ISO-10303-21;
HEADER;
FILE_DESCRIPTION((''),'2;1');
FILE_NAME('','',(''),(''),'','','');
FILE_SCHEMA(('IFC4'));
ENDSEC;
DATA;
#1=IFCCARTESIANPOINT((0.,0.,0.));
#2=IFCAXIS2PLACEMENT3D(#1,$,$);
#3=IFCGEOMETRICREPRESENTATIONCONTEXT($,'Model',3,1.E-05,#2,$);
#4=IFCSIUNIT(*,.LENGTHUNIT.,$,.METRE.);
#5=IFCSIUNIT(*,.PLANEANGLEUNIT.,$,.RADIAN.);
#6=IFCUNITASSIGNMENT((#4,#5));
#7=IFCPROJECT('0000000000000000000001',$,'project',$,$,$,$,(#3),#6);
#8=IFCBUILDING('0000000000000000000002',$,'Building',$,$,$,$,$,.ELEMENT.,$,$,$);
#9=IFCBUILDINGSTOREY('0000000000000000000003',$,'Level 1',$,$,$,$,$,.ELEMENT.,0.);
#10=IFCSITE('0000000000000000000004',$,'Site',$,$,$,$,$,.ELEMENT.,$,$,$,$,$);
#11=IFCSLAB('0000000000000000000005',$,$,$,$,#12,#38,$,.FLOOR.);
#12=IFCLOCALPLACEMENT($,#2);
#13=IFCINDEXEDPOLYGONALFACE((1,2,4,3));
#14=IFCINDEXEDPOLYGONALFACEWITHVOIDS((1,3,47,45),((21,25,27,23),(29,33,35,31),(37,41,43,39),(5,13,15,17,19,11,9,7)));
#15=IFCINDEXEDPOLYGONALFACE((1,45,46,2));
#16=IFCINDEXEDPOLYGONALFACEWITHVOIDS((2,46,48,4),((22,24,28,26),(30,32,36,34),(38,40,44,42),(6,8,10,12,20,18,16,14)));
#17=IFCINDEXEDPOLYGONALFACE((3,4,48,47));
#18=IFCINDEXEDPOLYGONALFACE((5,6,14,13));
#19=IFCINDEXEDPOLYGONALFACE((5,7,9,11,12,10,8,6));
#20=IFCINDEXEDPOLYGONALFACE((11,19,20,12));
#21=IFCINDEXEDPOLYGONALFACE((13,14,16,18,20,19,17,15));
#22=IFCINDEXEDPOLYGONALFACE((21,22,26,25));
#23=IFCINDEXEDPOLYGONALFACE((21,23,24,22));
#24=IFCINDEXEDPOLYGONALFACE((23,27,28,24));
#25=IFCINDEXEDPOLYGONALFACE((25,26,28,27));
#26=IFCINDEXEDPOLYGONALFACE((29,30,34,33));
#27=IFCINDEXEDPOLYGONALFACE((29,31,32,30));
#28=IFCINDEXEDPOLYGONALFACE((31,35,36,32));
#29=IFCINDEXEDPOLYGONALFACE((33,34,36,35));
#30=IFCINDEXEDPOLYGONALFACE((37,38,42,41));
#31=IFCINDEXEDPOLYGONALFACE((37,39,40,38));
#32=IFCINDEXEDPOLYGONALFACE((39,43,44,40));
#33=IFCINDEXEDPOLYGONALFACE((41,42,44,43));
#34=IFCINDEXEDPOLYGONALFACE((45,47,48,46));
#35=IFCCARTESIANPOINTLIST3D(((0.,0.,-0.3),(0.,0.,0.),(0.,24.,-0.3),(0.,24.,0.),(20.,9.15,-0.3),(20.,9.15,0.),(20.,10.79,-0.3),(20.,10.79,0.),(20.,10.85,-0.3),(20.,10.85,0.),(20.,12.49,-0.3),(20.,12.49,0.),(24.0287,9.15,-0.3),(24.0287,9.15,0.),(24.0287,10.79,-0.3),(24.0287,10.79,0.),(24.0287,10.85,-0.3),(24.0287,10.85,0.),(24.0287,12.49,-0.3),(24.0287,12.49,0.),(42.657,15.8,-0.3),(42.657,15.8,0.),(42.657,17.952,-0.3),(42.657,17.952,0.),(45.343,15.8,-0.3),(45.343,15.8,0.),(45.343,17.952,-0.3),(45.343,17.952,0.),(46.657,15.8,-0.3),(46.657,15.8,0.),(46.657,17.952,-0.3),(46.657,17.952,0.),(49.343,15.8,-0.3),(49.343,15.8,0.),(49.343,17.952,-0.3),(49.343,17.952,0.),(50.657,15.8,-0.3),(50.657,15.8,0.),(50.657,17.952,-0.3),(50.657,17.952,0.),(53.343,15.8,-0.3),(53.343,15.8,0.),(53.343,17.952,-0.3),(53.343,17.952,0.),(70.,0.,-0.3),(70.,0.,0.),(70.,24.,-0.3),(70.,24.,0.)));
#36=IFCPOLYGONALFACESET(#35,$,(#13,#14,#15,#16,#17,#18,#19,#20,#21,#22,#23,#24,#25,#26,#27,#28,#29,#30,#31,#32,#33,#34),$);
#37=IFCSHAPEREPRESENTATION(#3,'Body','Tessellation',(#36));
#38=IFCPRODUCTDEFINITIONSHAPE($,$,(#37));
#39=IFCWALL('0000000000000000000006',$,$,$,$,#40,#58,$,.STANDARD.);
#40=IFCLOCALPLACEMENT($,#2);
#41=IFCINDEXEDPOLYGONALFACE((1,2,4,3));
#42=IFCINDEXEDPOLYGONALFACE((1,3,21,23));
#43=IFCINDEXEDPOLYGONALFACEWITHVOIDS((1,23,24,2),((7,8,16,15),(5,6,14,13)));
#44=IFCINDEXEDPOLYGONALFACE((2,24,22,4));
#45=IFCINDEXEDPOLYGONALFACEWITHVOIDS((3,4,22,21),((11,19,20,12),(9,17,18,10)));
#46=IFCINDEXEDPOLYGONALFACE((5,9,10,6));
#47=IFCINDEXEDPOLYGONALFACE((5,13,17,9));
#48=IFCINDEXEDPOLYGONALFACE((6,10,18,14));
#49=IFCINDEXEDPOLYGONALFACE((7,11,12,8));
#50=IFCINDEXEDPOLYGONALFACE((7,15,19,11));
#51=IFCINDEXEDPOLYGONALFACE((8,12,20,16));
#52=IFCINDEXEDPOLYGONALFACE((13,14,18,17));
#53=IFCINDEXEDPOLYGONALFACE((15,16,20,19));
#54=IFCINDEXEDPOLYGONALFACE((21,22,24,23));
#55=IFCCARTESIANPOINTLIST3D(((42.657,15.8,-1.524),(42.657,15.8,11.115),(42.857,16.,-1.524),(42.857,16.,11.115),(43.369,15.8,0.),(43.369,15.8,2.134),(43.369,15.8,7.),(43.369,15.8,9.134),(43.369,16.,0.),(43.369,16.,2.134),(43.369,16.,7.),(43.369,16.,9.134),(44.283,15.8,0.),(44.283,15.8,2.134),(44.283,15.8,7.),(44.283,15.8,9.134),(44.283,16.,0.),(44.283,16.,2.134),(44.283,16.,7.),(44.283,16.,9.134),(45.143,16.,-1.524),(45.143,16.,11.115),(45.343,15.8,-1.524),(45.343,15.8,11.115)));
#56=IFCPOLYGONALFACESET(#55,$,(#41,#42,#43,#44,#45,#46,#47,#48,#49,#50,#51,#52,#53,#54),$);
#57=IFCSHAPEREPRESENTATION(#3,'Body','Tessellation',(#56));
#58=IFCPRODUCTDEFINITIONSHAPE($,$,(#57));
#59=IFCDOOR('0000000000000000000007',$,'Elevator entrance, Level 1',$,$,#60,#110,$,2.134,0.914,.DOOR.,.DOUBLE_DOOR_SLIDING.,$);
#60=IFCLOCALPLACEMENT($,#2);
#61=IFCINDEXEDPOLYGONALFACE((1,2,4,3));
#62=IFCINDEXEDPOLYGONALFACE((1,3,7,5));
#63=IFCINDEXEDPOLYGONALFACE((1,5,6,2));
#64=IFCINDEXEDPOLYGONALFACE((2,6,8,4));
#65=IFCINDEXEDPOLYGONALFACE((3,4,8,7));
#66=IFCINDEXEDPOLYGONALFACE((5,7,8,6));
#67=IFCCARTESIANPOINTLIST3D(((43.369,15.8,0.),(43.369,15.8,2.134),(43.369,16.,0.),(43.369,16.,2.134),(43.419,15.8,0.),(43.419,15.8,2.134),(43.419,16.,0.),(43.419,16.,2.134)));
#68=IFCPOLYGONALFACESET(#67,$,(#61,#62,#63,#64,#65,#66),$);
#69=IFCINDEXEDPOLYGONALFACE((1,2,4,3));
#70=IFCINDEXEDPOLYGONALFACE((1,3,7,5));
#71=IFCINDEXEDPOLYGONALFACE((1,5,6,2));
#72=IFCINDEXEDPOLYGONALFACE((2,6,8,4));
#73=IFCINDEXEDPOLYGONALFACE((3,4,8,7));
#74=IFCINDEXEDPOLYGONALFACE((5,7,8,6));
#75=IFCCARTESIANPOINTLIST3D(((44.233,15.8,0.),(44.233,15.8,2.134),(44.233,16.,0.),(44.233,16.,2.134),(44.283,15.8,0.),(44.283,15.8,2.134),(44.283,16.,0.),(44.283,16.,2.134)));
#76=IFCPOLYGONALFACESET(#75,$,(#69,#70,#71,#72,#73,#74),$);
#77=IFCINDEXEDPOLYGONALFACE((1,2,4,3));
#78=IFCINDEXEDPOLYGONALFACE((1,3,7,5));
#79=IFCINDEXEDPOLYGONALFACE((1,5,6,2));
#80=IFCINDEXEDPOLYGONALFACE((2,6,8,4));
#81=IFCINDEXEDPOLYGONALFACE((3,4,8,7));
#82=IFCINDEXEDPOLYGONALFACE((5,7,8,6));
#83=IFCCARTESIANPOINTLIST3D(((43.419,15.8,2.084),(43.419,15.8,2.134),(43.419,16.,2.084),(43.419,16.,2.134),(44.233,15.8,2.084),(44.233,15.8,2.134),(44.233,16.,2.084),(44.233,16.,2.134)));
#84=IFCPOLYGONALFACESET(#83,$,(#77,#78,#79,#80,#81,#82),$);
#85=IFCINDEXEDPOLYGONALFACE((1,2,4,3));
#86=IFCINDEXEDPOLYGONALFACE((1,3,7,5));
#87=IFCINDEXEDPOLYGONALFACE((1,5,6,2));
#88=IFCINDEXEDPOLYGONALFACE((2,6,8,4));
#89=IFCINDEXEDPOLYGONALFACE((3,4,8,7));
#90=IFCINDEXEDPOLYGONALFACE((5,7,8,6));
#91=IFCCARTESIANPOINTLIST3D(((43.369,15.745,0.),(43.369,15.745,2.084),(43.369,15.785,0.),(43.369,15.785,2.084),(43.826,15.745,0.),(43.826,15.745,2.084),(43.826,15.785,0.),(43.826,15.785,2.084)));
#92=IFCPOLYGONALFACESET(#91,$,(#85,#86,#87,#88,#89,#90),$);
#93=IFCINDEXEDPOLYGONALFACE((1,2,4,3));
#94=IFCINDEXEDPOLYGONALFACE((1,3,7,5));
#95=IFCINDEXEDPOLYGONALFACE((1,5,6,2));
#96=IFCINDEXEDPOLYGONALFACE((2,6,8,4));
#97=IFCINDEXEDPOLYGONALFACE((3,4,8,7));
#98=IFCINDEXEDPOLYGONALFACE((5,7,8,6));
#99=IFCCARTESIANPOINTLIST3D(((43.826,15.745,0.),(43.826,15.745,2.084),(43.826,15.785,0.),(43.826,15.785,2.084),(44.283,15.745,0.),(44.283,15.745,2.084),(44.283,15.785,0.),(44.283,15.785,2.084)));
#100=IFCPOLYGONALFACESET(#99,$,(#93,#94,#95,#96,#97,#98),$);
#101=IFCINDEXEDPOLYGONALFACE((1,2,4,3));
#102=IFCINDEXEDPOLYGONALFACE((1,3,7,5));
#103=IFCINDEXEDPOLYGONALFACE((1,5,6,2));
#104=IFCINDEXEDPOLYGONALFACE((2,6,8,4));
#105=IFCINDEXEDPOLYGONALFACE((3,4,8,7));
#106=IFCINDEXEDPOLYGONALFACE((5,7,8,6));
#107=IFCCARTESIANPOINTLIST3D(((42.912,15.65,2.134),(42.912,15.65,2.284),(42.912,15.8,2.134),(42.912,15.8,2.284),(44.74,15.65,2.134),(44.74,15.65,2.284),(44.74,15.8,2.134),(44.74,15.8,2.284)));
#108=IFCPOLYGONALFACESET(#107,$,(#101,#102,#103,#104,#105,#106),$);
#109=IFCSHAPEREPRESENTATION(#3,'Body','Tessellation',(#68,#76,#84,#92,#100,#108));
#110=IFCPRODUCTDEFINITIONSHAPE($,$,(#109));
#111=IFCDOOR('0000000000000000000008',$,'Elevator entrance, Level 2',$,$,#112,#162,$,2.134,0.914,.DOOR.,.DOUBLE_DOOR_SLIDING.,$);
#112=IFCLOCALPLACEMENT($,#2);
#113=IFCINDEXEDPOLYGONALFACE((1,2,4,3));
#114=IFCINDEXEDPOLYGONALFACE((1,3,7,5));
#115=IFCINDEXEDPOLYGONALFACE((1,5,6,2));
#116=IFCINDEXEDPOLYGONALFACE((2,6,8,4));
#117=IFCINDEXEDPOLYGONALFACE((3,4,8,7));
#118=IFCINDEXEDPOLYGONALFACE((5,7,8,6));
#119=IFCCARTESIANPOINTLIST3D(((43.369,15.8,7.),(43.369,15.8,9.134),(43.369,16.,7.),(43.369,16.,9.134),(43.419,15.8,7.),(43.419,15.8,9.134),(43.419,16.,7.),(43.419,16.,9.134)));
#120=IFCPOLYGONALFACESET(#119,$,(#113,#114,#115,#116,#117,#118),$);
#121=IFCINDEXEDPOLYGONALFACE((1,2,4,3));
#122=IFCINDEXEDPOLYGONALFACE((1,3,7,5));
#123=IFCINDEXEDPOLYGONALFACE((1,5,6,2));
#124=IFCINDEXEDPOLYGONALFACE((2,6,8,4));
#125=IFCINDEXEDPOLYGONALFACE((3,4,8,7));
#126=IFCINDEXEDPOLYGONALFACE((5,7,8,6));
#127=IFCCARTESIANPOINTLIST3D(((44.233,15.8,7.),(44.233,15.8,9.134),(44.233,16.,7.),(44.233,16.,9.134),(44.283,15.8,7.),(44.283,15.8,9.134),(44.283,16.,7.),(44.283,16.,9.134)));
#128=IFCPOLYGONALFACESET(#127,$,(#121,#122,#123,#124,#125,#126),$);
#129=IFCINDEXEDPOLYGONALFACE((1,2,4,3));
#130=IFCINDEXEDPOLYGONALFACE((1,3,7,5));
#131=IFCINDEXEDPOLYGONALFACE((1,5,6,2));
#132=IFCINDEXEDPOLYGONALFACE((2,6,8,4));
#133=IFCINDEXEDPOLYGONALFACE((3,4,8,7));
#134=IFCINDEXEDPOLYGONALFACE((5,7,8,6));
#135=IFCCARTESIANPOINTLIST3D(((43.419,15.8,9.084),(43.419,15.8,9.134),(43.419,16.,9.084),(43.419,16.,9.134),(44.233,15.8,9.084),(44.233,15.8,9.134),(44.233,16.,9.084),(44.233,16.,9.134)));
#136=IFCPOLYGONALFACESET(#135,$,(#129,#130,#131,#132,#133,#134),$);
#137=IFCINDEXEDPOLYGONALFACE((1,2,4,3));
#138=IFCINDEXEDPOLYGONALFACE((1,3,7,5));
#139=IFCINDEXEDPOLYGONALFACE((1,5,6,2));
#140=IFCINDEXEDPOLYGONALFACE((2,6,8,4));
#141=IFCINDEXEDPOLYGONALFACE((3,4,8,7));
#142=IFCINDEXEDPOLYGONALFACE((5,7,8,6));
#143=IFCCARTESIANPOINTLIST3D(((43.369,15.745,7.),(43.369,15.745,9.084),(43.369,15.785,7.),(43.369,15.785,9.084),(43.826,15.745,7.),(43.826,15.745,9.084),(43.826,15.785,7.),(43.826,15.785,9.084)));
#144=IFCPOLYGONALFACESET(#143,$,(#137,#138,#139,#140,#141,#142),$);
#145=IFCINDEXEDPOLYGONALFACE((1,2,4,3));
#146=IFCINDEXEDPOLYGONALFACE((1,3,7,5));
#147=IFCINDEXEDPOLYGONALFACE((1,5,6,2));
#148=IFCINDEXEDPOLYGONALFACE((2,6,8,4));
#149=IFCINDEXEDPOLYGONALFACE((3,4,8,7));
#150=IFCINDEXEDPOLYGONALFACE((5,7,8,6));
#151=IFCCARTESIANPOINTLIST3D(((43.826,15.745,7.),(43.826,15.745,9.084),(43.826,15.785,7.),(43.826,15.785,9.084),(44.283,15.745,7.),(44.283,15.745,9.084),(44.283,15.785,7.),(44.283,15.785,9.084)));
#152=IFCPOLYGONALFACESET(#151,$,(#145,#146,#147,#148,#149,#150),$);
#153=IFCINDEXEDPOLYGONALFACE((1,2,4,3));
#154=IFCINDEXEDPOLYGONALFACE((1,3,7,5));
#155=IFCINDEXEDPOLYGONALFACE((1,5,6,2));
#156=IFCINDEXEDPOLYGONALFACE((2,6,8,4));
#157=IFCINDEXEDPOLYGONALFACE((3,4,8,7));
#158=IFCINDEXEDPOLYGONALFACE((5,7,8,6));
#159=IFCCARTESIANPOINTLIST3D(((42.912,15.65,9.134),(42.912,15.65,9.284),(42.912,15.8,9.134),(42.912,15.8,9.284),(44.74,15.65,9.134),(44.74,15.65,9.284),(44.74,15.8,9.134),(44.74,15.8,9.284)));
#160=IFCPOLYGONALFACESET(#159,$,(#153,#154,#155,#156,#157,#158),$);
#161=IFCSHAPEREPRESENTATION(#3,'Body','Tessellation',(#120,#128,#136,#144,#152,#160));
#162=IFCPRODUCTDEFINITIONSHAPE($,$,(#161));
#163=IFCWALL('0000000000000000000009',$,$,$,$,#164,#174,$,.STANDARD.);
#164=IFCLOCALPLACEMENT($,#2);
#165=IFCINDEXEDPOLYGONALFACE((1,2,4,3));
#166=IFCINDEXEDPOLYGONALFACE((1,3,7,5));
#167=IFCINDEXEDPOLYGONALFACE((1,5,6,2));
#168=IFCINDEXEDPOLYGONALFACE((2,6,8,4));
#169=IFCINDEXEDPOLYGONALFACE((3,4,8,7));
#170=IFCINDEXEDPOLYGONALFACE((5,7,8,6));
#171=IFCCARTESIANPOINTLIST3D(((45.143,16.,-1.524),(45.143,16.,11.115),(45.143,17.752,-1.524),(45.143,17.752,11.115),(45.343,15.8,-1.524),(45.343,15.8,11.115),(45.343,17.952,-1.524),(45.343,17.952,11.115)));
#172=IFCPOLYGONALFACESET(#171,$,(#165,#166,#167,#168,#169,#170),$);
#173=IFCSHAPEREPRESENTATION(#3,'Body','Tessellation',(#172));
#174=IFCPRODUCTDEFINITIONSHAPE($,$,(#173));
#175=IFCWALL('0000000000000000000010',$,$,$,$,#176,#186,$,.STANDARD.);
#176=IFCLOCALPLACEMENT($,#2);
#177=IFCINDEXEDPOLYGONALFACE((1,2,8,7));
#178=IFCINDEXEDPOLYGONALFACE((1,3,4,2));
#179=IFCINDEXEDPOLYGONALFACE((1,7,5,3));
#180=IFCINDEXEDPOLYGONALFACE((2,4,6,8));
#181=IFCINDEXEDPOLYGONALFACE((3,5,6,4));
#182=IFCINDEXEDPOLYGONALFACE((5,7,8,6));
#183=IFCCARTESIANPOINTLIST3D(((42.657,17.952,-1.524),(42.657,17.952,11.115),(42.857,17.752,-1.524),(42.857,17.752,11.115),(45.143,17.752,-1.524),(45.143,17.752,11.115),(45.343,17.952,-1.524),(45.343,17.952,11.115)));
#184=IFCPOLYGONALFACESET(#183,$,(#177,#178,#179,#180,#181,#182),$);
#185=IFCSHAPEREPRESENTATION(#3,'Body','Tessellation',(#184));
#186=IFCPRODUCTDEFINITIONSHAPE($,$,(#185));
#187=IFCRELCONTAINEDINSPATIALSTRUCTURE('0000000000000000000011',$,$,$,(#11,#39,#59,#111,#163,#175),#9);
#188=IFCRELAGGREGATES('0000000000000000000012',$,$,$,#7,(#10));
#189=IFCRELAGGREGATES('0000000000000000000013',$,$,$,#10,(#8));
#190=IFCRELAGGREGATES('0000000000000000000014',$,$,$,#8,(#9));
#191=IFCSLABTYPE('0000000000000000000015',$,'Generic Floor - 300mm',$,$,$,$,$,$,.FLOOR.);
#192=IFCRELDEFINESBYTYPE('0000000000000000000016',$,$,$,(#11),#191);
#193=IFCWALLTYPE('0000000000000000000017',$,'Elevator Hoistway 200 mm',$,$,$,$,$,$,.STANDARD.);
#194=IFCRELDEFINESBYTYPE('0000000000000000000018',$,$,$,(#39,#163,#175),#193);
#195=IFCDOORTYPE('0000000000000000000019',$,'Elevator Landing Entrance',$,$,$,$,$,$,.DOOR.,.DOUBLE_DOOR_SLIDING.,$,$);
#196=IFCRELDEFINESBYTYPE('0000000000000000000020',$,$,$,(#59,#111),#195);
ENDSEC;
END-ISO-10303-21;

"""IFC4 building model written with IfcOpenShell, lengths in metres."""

from ifc_helpers import new_model, si_unit, frame, frame_2d, origin, origin_with_axes, origin_2d, place, context, project, spatial, polyline, rectangle, outline, extrude, type_object, element, fill, save


model = new_model("IFC4")

# Units and contexts
model_context = context("Model", 3, precision=1e-05, world=origin())
ifc_project = project(units=[si_unit("LENGTHUNIT", "METRE"), si_unit("PLANEANGLEUNIT", "RADIAN")], contexts=[model_context])

# Site, building, storey
site = spatial("IfcSite", under=ifc_project, Name="Site", CompositionType="ELEMENT")
building = spatial("IfcBuilding", under=site, Name="Building", CompositionType="ELEMENT")
storey = spatial("IfcBuildingStorey", under=building, Name="Level 1", CompositionType="ELEMENT", Elevation=0.0)

# Slab, openings
slab_type = type_object("IfcSlabType", Name="Generic Floor - 300mm", PredefinedType="FLOOR")
slab_placement = place(None, origin())
slab = element("IfcSlab", 1, at=slab_placement, inside=storey, type_object=slab_type, PredefinedType="FLOOR", context=model_context, shape_type="SweptSolid", body=[
    extrude(outline(polyline([(0.0, 0.0), (70.0, 0.0), (70.0, 24.0), (0.0, 24.0), (0.0, 0.0)])), origin(), (0.0, 0.0, -1.0), 0.3),
])
opening_1_placement = place(None, frame((0.0, 0.0, 0.001)))
element("IfcOpeningElement", 2, at=opening_1_placement, cuts=slab, PredefinedType="OPENING", context=model_context, shape_type="SweptSolid", body=[
    extrude(outline(polyline([(20.0, 9.15), (24.0287, 9.15), (24.0287, 10.85), (20.0, 10.85), (20.0, 9.15)])), origin(), (0.0, 0.0, -1.0), 0.302),
])
opening_2_placement = place(None, frame((0.0, 0.0, 0.001)))
element("IfcOpeningElement", 3, at=opening_2_placement, cuts=slab, PredefinedType="OPENING", context=model_context, shape_type="SweptSolid", body=[
    extrude(outline(polyline([(20.0, 10.79), (24.0287, 10.79), (24.0287, 12.49), (20.0, 12.49), (20.0, 10.79)])), origin(), (0.0, 0.0, -1.0), 0.302),
])
opening_3_placement = place(None, frame((0.0, 0.0, 0.001)))
element("IfcOpeningElement", 4, at=opening_3_placement, cuts=slab, PredefinedType="OPENING", context=model_context, shape_type="SweptSolid", body=[
    extrude(outline(polyline([(42.657, 15.8), (45.343, 15.8), (45.343, 17.952), (42.657, 17.952), (42.657, 15.8)])), origin(), (0.0, 0.0, -1.0), 0.302),
])
opening_4_placement = place(None, frame((0.0, 0.0, 0.001)))
element("IfcOpeningElement", 5, at=opening_4_placement, cuts=slab, PredefinedType="OPENING", context=model_context, shape_type="SweptSolid", body=[
    extrude(outline(polyline([(46.657, 15.8), (49.343, 15.8), (49.343, 17.952), (46.657, 17.952), (46.657, 15.8)])), origin(), (0.0, 0.0, -1.0), 0.302),
])
opening_5_placement = place(None, frame((0.0, 0.0, 0.001)))
element("IfcOpeningElement", 6, at=opening_5_placement, cuts=slab, PredefinedType="OPENING", context=model_context, shape_type="SweptSolid", body=[
    extrude(outline(polyline([(50.657, 15.8), (53.343, 15.8), (53.343, 17.952), (50.657, 17.952), (50.657, 15.8)])), origin(), (0.0, 0.0, -1.0), 0.302),
])

# Wall, openings, doors
wall_type = type_object("IfcWallType", Name="Elevator Hoistway 200 mm", PredefinedType="STANDARD")
wall_1_placement = place(None, frame((42.757, 15.9, -1.524), z_axis=(0.0, 0.0, 1.0), x_axis=(1.0, 0.0, 0.0)))
wall_1 = element("IfcWall", 7, at=wall_1_placement, inside=storey, type_object=wall_type, PredefinedType="STANDARD", context=model_context, shape_type="SweptSolid", body=[
    extrude(outline(polyline([(-0.1, -0.1), (2.586, -0.1), (2.386, 0.1), (0.1, 0.1), (-0.1, -0.1)])), origin(), (0.0, 0.0, 1.0), 12.639),
])
opening_6_placement = place(wall_1_placement, frame((1.069, 0.0, 1.524), z_axis=(0.0, 0.0, 1.0), x_axis=(1.0, 0.0, 0.0)))
opening_6 = element("IfcOpeningElement", 8, at=opening_6_placement, cuts=wall_1, PredefinedType="OPENING", context=model_context, shape_type="SweptSolid", body=[
    extrude(rectangle(XDim=0.914, YDim=0.202, at=origin_2d()), origin(), (0.0, 0.0, 1.0), 2.134),
])
opening_7_placement = place(wall_1_placement, frame((1.069, 0.0, 8.524), z_axis=(0.0, 0.0, 1.0), x_axis=(1.0, 0.0, 0.0)))
opening_7 = element("IfcOpeningElement", 9, at=opening_7_placement, cuts=wall_1, PredefinedType="OPENING", context=model_context, shape_type="SweptSolid", body=[
    extrude(rectangle(XDim=0.914, YDim=0.202, at=origin_2d()), origin(), (0.0, 0.0, 1.0), 2.134),
])
door_type = type_object("IfcDoorType", Name="Elevator Landing Entrance", OperationType="DOUBLE_DOOR_SLIDING", PredefinedType="DOOR")
door_1_placement = place(opening_6_placement, origin_with_axes())
door_1 = element("IfcDoor", 10, at=door_1_placement, inside=storey, type_object=door_type, Name="Elevator entrance, Level 1", OperationType="DOUBLE_DOOR_SLIDING", OverallHeight=2.134, OverallWidth=0.914, PredefinedType="DOOR", context=model_context, shape_type="SweptSolid", body=[
    extrude(rectangle(XDim=0.05, YDim=0.2, at=frame_2d((-0.432, 0.0))), origin(), (0.0, 0.0, 1.0), 2.134),
    extrude(rectangle(XDim=0.05, YDim=0.2, at=frame_2d((0.432, 0.0))), origin(), (0.0, 0.0, 1.0), 2.134),
    extrude(rectangle(XDim=0.814, YDim=0.2, at=origin_2d()), frame((0.0, 0.0, 2.084)), (0.0, 0.0, 1.0), 0.05),
    extrude(rectangle(XDim=0.457, YDim=0.04, at=frame_2d((-0.2285, -0.135))), origin(), (0.0, 0.0, 1.0), 2.084),
    extrude(rectangle(XDim=0.457, YDim=0.04, at=frame_2d((0.2285, -0.135))), origin(), (0.0, 0.0, 1.0), 2.084),
    extrude(rectangle(XDim=1.828, YDim=0.15, at=frame_2d((0.0, -0.175))), frame((0.0, 0.0, 2.134)), (0.0, 0.0, 1.0), 0.15),
])
fill(opening_6, door_1)
door_2_placement = place(opening_7_placement, origin_with_axes())
door_2 = element("IfcDoor", 11, at=door_2_placement, inside=storey, type_object=door_type, Name="Elevator entrance, Level 2", OperationType="DOUBLE_DOOR_SLIDING", OverallHeight=2.134, OverallWidth=0.914, PredefinedType="DOOR", context=model_context, shape_type="SweptSolid", body=[
    extrude(rectangle(XDim=0.05, YDim=0.2, at=frame_2d((-0.432, 0.0))), origin(), (0.0, 0.0, 1.0), 2.134),
    extrude(rectangle(XDim=0.05, YDim=0.2, at=frame_2d((0.432, 0.0))), origin(), (0.0, 0.0, 1.0), 2.134),
    extrude(rectangle(XDim=0.814, YDim=0.2, at=origin_2d()), frame((0.0, 0.0, 2.084)), (0.0, 0.0, 1.0), 0.05),
    extrude(rectangle(XDim=0.457, YDim=0.04, at=frame_2d((-0.2285, -0.135))), origin(), (0.0, 0.0, 1.0), 2.084),
    extrude(rectangle(XDim=0.457, YDim=0.04, at=frame_2d((0.2285, -0.135))), origin(), (0.0, 0.0, 1.0), 2.084),
    extrude(rectangle(XDim=1.828, YDim=0.15, at=frame_2d((0.0, -0.175))), frame((0.0, 0.0, 2.134)), (0.0, 0.0, 1.0), 0.15),
])
fill(opening_7, door_2)

# Walls
wall_2_placement = place(None, frame((45.243, 15.9, -1.524), z_axis=(0.0, 0.0, 1.0), x_axis=(0.0, 1.0, 0.0)))
element("IfcWall", 12, at=wall_2_placement, inside=storey, type_object=wall_type, PredefinedType="STANDARD", context=model_context, shape_type="SweptSolid", body=[
    extrude(outline(polyline([(-0.1, -0.1), (2.052, -0.1), (1.852, 0.1), (0.1, 0.1), (-0.1, -0.1)])), origin(), (0.0, 0.0, 1.0), 12.639),
])
wall_3_placement = place(None, frame((45.243, 17.852, -1.524), z_axis=(0.0, 0.0, 1.0), x_axis=(-1.0, 0.0, 0.0)))
element("IfcWall", 13, at=wall_3_placement, inside=storey, type_object=wall_type, PredefinedType="STANDARD", context=model_context, shape_type="SweptSolid", body=[
    extrude(outline(polyline([(-0.1, -0.1), (2.586, -0.1), (2.386, 0.1), (0.1, 0.1), (-0.1, -0.1)])), origin(), (0.0, 0.0, 1.0), 12.639),
])

save(model, "model.ifc")
